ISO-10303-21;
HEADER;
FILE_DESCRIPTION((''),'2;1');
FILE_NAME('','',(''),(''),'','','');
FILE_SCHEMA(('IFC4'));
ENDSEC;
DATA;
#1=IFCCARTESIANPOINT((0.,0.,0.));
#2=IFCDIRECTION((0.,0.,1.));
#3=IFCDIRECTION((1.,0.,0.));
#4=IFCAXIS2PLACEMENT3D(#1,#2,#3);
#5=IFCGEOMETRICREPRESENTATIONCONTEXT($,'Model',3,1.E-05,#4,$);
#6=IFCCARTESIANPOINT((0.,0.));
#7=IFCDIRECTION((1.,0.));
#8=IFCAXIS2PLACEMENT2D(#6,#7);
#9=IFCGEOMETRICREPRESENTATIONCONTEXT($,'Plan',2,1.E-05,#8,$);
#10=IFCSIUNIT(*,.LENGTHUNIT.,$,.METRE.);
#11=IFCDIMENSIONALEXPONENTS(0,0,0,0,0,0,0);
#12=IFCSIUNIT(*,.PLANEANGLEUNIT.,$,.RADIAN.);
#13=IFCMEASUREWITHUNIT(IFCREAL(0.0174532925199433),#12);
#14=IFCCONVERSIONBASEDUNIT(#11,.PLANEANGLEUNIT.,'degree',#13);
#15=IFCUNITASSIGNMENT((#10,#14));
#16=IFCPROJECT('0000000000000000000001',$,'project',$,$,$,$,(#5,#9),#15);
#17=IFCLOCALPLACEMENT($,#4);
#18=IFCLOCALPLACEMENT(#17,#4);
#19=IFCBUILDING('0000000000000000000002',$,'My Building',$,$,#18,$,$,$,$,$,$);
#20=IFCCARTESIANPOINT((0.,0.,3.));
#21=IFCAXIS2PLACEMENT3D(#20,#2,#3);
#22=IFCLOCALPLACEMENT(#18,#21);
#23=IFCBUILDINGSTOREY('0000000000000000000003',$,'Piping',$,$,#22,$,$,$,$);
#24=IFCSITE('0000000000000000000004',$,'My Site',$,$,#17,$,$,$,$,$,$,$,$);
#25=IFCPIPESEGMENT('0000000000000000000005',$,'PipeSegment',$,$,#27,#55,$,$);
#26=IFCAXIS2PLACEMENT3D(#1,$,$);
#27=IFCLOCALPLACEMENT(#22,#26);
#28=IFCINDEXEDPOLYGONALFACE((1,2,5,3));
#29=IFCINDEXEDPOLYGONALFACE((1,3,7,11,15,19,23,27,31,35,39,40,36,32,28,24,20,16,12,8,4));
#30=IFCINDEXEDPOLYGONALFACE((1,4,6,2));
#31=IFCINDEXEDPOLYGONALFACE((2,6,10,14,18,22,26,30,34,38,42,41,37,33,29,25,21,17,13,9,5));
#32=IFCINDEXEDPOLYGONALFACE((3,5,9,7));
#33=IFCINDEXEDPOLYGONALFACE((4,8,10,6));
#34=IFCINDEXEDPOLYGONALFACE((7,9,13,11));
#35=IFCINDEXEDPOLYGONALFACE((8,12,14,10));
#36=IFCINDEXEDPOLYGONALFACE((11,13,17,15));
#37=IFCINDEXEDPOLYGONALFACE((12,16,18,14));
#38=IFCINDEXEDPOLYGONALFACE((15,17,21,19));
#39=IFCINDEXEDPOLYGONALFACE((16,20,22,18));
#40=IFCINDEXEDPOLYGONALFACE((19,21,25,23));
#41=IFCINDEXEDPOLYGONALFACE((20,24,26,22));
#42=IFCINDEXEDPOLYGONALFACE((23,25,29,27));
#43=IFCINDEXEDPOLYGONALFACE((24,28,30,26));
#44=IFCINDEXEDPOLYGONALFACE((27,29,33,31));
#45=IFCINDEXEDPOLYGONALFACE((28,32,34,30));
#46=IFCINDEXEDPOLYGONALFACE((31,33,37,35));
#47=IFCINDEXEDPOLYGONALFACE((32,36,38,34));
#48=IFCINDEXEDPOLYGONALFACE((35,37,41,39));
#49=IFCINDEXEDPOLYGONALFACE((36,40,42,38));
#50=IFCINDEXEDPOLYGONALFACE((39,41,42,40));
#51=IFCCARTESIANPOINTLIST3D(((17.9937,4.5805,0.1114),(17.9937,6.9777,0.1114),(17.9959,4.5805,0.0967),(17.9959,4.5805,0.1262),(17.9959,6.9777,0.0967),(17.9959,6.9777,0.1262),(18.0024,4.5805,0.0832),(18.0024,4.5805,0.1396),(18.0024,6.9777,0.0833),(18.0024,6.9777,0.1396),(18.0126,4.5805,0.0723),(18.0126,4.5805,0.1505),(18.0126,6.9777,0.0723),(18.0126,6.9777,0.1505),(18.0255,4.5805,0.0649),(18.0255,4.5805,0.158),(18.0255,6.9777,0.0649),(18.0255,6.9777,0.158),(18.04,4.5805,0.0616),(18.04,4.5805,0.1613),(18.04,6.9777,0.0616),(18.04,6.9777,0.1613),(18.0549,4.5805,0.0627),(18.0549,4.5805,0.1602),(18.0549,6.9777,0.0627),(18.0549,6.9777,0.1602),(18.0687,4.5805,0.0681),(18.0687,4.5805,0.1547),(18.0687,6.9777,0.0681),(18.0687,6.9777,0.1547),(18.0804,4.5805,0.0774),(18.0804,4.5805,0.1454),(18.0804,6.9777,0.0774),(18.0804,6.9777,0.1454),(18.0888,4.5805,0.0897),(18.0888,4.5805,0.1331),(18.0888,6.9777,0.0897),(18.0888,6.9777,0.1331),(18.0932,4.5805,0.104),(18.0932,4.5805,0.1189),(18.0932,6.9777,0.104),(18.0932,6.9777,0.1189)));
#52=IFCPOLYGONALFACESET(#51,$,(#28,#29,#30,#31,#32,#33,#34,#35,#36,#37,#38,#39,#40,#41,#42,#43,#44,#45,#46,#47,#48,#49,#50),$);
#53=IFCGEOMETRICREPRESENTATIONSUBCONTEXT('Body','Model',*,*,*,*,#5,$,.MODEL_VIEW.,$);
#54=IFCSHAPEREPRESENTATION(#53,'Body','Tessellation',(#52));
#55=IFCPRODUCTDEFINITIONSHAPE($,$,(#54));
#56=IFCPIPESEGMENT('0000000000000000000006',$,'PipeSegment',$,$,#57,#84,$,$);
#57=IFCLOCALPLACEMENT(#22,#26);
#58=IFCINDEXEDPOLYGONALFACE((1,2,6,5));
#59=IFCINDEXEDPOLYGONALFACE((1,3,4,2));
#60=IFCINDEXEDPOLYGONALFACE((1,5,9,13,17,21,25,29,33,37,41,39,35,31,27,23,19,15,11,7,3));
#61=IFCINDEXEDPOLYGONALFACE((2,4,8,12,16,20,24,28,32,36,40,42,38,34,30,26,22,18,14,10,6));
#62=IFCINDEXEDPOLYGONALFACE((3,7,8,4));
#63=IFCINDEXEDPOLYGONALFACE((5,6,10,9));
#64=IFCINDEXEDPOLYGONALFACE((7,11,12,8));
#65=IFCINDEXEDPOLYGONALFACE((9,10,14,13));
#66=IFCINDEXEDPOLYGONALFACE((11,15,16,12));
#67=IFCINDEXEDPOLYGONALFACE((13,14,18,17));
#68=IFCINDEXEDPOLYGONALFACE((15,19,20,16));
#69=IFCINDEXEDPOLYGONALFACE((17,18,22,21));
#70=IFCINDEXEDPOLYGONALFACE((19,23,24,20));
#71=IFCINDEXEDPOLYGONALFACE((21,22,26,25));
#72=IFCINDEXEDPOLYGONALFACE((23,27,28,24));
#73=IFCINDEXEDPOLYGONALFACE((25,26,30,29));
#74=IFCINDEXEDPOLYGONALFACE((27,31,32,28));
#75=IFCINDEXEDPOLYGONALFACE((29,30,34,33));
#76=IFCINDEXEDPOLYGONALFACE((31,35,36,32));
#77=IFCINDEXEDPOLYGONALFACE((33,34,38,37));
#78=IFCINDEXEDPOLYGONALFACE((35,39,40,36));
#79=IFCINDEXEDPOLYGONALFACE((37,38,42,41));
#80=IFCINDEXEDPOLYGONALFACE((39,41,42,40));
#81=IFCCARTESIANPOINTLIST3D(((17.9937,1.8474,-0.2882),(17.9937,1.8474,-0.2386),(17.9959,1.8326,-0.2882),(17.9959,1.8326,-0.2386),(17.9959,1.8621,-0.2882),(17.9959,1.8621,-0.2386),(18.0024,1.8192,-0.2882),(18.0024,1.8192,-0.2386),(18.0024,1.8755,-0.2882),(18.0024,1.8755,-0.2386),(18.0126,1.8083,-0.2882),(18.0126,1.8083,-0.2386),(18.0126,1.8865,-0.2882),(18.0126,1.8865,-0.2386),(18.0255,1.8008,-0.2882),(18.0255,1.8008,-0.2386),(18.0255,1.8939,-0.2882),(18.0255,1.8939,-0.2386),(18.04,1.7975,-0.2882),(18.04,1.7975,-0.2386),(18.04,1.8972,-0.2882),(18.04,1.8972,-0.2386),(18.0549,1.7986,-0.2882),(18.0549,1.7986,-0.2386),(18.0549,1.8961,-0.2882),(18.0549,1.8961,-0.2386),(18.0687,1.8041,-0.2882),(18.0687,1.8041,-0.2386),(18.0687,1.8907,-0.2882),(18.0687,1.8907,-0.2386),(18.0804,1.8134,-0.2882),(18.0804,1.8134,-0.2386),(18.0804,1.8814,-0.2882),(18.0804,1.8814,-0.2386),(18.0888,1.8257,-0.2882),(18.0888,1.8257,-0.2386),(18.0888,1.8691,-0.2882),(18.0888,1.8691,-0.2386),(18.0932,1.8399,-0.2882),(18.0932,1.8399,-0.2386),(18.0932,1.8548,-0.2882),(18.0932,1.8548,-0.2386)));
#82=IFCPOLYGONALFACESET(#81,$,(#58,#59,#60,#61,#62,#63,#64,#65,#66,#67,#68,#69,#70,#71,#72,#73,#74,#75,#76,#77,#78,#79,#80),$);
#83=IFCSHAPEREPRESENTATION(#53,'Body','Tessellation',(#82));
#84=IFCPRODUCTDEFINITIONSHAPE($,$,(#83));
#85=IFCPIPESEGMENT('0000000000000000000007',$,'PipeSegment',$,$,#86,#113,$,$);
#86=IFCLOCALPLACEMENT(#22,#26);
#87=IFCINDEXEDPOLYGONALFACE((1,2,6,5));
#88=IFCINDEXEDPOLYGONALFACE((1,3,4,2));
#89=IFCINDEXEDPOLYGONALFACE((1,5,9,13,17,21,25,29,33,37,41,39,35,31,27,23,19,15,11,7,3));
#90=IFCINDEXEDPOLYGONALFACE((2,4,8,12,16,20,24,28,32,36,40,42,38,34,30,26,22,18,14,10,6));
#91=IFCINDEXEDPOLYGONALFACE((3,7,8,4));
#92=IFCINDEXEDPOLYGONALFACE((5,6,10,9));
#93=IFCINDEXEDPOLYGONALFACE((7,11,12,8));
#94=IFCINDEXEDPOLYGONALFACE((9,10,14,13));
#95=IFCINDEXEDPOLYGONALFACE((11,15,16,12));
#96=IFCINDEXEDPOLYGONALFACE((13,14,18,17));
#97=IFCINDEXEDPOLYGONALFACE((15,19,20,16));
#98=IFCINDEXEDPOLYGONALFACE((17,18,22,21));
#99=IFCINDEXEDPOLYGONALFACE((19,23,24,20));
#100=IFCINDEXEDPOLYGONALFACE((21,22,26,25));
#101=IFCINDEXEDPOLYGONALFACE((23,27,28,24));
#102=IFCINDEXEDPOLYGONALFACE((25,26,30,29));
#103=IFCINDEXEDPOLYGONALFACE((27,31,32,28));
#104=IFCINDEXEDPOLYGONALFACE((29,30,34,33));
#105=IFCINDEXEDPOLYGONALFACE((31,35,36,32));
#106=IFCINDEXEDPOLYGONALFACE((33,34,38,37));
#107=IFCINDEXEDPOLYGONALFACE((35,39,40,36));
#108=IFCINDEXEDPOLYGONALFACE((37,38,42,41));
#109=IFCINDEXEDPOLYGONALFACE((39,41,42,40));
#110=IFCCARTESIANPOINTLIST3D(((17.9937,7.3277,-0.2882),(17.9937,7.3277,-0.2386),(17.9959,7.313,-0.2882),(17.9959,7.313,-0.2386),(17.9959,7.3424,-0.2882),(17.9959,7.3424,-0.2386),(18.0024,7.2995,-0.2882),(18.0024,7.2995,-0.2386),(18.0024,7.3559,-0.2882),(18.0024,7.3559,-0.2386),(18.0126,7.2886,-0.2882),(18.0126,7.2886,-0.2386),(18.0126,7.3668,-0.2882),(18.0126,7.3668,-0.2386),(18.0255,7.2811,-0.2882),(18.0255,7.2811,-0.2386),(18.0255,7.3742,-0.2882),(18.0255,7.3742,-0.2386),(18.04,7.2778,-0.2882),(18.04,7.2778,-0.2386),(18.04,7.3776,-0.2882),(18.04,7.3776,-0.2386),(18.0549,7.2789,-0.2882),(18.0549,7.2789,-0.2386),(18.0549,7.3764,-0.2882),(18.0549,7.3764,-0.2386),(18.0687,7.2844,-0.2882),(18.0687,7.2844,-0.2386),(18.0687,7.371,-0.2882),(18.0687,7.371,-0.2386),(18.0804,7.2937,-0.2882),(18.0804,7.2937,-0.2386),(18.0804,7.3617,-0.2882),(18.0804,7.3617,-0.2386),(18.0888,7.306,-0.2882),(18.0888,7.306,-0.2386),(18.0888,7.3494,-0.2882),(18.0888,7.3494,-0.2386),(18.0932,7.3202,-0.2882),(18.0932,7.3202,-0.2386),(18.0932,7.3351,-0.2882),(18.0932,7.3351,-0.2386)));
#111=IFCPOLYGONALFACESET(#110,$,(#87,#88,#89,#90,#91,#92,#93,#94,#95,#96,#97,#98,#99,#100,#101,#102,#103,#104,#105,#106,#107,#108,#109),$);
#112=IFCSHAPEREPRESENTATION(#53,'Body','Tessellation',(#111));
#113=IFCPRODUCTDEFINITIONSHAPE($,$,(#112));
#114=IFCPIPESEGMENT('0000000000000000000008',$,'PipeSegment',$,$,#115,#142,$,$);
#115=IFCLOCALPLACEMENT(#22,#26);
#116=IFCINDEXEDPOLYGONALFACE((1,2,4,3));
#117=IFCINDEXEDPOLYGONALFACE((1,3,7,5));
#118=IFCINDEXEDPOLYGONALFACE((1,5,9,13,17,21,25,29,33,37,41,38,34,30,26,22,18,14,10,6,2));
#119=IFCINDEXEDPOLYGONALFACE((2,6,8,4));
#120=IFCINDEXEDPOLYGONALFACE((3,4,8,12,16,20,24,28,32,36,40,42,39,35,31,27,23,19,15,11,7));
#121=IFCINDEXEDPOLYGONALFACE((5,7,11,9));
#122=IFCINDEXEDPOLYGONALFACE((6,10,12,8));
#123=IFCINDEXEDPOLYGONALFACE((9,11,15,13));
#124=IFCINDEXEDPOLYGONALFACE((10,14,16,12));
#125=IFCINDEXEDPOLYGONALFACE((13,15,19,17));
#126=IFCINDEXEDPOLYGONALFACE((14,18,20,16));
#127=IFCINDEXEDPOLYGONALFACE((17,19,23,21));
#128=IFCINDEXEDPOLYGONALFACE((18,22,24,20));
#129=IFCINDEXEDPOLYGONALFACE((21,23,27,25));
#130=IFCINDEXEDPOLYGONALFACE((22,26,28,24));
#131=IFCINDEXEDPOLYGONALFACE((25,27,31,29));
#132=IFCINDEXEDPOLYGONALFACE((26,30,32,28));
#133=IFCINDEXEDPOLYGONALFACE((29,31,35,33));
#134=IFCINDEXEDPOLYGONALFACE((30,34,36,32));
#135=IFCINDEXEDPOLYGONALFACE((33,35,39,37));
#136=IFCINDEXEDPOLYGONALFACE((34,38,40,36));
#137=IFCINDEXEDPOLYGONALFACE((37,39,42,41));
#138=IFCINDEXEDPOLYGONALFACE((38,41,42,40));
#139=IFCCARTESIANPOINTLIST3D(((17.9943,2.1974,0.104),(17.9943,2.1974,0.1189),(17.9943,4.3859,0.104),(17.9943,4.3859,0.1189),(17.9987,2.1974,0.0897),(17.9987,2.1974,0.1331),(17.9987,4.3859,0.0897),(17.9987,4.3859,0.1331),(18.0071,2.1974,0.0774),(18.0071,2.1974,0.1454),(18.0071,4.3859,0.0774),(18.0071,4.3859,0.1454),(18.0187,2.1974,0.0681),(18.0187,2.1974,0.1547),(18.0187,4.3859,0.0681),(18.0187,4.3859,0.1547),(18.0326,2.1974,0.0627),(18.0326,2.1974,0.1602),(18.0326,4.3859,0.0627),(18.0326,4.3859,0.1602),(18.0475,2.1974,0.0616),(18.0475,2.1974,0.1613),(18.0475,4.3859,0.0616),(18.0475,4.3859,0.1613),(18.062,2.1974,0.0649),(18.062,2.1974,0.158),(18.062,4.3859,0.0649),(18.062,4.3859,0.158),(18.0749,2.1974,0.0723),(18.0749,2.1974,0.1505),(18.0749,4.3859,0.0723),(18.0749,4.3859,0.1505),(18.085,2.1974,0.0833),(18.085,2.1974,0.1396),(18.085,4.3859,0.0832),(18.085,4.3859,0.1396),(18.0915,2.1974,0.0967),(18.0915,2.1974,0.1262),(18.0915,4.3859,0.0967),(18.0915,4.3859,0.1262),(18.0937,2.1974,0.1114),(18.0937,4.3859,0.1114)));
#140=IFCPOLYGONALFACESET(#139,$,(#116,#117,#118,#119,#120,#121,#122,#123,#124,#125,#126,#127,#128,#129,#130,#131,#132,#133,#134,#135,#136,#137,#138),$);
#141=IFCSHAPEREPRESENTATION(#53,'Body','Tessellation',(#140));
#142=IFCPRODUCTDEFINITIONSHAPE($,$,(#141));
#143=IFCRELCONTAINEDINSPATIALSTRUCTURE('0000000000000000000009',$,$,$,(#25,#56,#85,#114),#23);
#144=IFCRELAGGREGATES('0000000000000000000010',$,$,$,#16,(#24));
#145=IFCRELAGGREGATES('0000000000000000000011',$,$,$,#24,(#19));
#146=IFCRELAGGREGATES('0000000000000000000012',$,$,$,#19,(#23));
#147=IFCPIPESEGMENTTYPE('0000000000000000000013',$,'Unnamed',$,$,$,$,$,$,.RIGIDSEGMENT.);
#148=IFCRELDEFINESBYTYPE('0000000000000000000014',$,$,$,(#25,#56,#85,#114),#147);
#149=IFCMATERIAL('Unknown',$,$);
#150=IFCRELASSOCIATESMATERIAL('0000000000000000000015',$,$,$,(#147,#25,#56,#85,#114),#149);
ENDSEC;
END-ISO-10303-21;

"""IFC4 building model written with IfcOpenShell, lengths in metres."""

from ifc_helpers import new_model, entity, si_unit, converted_unit, frame, origin_with_axes, origin_2d_with_axis, place, context, subcontext, project, spatial, circle, extrude, material, material_profile, profile_set, profile_usage, type_object, element, save


model = new_model("IFC4")

# Units and contexts
model_context = context("Model", 3, precision=1e-05, world=origin_with_axes())
plan_context = context("Plan", 2, precision=1e-05, world=origin_2d_with_axis())
body_context = subcontext(model_context, "Body", "Model", "MODEL_VIEW")
ifc_project = project(units=[si_unit("LENGTHUNIT", "METRE"), converted_unit("PLANEANGLEUNIT", "degree", entity("IfcReal", 0.0174532925199433), si_unit("PLANEANGLEUNIT", "RADIAN"), dimensions=[0, 0, 0, 0, 0, 0, 0])], contexts=[model_context, plan_context])

# Site, building, storey
site_placement = place(None, origin_with_axes())
site = spatial("IfcSite", under=ifc_project, at=site_placement, Name="My Site")
building_placement = place(site_placement, origin_with_axes())
building = spatial("IfcBuilding", under=site, at=building_placement, Name="My Building")
storey_placement = place(building_placement, frame((0.0, 0.0, 3.0), z_axis=(0.0, 0.0, 1.0), x_axis=(1.0, 0.0, 0.0)))
storey = spatial("IfcBuildingStorey", under=building, at=storey_placement, Name="Piping")

# Pipe segments
ifc_material = material(Name="Unknown")
ifc_material_profile_1 = material_profile(ifc_material, circle(Radius=0.05))
ifc_profile_set_1 = profile_set([ifc_material_profile_1])
pipe_segment_type = type_object("IfcPipeSegmentType", Name="Unnamed", PredefinedType="RIGIDSEGMENT", material=ifc_profile_set_1)
ifc_profile_usage_1 = profile_usage(ifc_profile_set_1, cardinal=16)
pipe_segment_1_placement = place(storey_placement, frame((18.0437, 4.5805, 0.1114), z_axis=(0.0, 1.0, 0.0), x_axis=(-1.0, 0.0, 0.0)))
element("IfcPipeSegment", 1, at=pipe_segment_1_placement, inside=storey, type_object=pipe_segment_type, material=ifc_profile_usage_1, Name="PipeSegment", context=body_context, shape_type="SweptSolid", body=[
    extrude(circle(Radius=0.05), origin_with_axes(), (0.0, 0.0, 1.0), 2.3972),
])
ifc_profile_usage_2 = profile_usage(ifc_profile_set_1, cardinal=16)
pipe_segment_2_placement = place(storey_placement, frame((18.0437, 1.8474, -0.2386), z_axis=(0.0, 0.0, -1.0), x_axis=(-1.0, 0.0, 0.0)))
element("IfcPipeSegment", 2, at=pipe_segment_2_placement, inside=storey, type_object=pipe_segment_type, material=ifc_profile_usage_2, Name="PipeSegment", context=body_context, shape_type="SweptSolid", body=[
    extrude(circle(Radius=0.05), origin_with_axes(), (0.0, 0.0, 1.0), 0.0496),
])
ifc_profile_usage_3 = profile_usage(ifc_profile_set_1, cardinal=16)
pipe_segment_3_placement = place(storey_placement, frame((18.0437, 7.3277, -0.2386), z_axis=(0.0, 0.0, -1.0), x_axis=(-1.0, 0.0, 0.0)))
element("IfcPipeSegment", 3, at=pipe_segment_3_placement, inside=storey, type_object=pipe_segment_type, material=ifc_profile_usage_3, Name="PipeSegment", context=body_context, shape_type="SweptSolid", body=[
    extrude(circle(Radius=0.05), origin_with_axes(), (0.0, 0.0, 1.0), 0.0496),
])
ifc_profile_usage_4 = profile_usage(ifc_profile_set_1, cardinal=16)
pipe_segment_4_placement = place(storey_placement, frame((18.0437, 4.3859, 0.1114), z_axis=(0.0, -1.0, 0.0), x_axis=(1.0, 0.0, 0.0)))
element("IfcPipeSegment", 4, at=pipe_segment_4_placement, inside=storey, type_object=pipe_segment_type, material=ifc_profile_usage_4, Name="PipeSegment", context=body_context, shape_type="SweptSolid", body=[
    extrude(circle(Radius=0.05), origin_with_axes(), (0.0, 0.0, 1.0), 2.1885),
])

save(model, "model.ifc")
